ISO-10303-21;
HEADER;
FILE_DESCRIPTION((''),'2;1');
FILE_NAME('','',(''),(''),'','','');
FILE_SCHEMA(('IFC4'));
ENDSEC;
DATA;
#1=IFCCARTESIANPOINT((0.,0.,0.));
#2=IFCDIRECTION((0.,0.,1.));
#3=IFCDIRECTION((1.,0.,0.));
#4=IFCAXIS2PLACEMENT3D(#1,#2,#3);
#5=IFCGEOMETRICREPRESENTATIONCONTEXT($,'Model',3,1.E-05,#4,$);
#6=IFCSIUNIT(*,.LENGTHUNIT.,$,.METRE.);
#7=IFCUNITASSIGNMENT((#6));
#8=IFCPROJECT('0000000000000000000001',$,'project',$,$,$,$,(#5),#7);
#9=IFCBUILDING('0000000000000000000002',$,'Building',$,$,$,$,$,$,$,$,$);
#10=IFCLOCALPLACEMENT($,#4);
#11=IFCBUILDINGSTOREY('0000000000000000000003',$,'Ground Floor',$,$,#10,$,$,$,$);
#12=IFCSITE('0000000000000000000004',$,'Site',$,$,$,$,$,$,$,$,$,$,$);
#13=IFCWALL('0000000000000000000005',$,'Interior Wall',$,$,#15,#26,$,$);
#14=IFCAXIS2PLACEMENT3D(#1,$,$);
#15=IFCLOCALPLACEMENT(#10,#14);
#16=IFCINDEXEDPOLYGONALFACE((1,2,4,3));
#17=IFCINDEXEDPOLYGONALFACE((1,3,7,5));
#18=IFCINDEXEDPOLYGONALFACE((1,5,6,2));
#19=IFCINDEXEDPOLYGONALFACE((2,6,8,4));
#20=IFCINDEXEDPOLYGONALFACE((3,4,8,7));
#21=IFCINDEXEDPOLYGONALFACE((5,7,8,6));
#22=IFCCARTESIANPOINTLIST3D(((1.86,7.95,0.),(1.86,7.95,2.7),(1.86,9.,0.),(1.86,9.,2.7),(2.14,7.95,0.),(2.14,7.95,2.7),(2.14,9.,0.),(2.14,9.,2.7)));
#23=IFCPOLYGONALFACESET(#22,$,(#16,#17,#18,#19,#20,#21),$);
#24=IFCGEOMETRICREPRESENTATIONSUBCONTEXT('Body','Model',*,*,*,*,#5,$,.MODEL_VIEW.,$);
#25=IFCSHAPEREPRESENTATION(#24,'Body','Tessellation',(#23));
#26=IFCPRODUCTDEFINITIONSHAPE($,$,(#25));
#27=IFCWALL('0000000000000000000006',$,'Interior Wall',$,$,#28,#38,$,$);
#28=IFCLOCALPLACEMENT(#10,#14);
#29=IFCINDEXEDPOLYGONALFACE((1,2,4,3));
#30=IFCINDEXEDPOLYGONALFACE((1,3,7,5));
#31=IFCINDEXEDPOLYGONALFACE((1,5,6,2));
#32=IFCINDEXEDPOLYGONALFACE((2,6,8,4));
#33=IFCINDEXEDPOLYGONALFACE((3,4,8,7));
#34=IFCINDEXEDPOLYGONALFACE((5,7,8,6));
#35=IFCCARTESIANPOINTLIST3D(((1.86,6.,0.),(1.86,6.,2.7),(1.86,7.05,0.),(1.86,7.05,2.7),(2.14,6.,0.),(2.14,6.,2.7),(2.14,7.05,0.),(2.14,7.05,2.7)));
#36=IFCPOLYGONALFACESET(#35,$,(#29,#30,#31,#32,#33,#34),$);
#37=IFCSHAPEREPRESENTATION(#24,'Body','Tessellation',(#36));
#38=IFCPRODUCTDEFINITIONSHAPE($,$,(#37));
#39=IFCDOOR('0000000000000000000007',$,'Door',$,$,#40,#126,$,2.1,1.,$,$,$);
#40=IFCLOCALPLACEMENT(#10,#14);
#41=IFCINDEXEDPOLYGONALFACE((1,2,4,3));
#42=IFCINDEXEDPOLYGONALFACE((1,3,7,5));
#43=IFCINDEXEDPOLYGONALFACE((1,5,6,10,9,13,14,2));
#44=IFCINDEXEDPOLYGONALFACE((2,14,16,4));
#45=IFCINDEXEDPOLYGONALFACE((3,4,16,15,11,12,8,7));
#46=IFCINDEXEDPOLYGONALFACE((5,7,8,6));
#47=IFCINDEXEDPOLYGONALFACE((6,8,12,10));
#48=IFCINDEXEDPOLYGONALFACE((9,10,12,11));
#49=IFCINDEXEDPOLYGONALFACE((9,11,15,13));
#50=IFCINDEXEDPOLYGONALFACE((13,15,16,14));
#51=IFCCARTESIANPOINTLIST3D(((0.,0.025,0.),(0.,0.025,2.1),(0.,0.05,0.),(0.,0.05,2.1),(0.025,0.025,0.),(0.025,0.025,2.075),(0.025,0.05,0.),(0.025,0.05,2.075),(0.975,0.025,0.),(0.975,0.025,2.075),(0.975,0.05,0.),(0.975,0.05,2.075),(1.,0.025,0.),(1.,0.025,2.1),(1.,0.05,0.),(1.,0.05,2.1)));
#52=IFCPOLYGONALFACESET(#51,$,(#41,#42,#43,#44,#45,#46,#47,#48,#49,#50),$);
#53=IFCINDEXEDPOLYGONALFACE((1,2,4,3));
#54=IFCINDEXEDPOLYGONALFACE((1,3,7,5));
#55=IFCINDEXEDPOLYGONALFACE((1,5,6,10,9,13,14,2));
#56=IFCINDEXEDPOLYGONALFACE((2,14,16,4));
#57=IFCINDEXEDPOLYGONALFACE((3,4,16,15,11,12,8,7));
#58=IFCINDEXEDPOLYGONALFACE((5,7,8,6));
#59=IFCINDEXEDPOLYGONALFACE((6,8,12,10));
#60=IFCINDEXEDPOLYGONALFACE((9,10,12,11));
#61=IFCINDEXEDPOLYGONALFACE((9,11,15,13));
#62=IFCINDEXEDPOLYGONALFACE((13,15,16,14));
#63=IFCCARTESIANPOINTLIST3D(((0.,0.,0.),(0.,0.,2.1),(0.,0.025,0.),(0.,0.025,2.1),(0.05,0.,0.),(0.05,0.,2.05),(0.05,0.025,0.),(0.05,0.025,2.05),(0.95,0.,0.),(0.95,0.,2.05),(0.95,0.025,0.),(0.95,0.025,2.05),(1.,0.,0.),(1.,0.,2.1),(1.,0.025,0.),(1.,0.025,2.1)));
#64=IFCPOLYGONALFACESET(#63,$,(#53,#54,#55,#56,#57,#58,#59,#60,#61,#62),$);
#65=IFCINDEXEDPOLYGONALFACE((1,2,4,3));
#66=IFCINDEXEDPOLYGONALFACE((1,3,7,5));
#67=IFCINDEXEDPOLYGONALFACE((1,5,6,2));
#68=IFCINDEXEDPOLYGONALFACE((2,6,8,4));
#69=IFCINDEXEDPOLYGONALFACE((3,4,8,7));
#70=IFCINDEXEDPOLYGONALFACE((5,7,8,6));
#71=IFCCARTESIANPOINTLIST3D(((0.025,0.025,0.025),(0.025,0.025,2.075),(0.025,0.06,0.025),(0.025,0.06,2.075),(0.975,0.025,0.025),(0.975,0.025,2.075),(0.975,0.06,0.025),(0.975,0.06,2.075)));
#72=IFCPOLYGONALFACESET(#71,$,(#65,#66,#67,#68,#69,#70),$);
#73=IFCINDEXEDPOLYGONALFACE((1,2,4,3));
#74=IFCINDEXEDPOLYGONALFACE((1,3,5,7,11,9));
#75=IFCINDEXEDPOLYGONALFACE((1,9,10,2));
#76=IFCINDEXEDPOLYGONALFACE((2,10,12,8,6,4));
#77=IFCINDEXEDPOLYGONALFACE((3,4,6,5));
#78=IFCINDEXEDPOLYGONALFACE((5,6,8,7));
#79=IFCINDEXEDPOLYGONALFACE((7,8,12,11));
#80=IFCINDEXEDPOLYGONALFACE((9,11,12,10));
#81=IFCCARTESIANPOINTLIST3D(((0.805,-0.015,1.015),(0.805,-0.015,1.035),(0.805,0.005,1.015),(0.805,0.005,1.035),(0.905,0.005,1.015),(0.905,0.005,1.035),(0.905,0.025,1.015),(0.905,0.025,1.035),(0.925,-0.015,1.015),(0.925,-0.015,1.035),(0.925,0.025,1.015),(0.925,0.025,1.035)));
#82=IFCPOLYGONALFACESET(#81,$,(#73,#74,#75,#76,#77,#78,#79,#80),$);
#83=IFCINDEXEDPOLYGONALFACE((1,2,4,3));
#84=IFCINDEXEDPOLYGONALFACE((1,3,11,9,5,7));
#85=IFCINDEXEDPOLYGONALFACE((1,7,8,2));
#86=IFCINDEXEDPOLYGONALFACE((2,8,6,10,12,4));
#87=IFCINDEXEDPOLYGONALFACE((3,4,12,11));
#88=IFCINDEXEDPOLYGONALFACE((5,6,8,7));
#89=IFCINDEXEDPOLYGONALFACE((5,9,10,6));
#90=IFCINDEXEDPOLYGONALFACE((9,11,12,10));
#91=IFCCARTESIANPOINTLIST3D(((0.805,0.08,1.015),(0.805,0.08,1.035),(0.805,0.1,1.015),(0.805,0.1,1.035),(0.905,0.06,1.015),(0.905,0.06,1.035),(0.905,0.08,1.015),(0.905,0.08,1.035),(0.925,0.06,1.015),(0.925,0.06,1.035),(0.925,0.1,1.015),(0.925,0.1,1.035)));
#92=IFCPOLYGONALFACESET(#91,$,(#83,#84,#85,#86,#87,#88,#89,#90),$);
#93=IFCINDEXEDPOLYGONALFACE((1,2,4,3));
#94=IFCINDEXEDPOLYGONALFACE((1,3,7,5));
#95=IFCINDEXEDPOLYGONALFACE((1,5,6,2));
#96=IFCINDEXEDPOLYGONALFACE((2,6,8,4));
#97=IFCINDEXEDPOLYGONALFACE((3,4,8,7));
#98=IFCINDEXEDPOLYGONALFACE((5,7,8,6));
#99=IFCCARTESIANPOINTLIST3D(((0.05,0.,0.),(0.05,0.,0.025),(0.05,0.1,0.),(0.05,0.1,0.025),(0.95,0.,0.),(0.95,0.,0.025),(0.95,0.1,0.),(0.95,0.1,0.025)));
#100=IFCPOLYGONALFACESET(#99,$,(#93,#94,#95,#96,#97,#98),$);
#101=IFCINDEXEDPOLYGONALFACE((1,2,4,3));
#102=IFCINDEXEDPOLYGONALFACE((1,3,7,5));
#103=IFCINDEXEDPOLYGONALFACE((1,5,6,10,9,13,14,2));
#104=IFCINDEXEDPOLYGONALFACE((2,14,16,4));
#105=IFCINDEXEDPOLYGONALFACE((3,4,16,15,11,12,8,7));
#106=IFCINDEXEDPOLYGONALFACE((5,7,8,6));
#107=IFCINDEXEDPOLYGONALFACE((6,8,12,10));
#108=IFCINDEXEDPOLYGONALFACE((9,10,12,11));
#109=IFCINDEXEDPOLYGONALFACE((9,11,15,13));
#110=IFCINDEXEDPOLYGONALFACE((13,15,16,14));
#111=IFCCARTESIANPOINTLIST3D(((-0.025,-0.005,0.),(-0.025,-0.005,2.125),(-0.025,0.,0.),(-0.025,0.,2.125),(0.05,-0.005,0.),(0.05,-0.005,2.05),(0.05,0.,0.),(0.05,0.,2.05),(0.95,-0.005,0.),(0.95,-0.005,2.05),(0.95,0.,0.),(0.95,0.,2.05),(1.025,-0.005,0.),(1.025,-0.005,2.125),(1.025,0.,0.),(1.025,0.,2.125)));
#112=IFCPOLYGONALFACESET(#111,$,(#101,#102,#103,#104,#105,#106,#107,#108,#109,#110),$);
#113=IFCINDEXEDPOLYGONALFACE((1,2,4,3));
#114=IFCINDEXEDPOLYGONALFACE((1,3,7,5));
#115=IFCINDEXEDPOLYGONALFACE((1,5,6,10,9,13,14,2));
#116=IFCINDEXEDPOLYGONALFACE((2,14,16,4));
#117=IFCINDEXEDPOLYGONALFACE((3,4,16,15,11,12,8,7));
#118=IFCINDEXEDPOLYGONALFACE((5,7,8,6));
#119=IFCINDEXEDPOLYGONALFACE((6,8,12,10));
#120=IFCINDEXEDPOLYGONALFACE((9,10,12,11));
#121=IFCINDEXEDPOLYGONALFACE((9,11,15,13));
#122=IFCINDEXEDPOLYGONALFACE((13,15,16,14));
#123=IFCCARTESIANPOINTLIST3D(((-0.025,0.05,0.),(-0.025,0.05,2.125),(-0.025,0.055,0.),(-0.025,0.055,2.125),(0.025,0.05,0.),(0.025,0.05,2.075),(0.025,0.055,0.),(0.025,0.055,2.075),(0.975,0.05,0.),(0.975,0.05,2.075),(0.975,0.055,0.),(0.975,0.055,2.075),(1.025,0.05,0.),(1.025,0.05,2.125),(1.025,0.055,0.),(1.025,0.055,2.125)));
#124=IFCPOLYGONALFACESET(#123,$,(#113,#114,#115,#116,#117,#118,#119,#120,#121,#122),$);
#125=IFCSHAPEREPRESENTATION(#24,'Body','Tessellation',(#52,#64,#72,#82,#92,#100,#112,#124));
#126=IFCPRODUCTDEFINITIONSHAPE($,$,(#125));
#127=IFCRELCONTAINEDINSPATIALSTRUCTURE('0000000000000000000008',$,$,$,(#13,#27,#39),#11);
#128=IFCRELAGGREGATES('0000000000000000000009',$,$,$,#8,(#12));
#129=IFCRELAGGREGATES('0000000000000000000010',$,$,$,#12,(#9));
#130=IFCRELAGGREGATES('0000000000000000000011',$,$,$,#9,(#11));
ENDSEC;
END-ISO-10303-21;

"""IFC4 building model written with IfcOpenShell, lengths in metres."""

from ifc_helpers import new_model, si_unit, frame, origin_with_axes, place, context, subcontext, project, spatial, line, indexed_curve, outline, extrude, element, save


model = new_model("IFC4")

# Units and contexts
model_context = context("Model", 3, precision=1e-05, world=origin_with_axes())
body_context = subcontext(model_context, "Body", "Model", "MODEL_VIEW")
ifc_project = project(units=[si_unit("LENGTHUNIT", "METRE")], contexts=[model_context])

# Site, building, storey
site = spatial("IfcSite", under=ifc_project, Name="Site")
building = spatial("IfcBuilding", under=site, Name="Building")
storey_placement = place(None, origin_with_axes())
storey = spatial("IfcBuildingStorey", under=building, at=storey_placement, Name="Ground Floor")

# Walls
for number, where, z_axis, x_axis, name in (
    (1, (2.0, 9.0, 0.0), (0.0, 0.0, 1.0), (0.0, -1.0, 0.0), "Interior Wall"),
    (2, (2.0, 7.05, 0.0), (0.0, 0.0, 1.0), (0.0, -1.0, 0.0), "Interior Wall"),
):
    element("IfcWall", number, at=place(storey_placement, frame(where, z_axis=z_axis, x_axis=x_axis)), inside=storey, Name=name, context=body_context, shape_type="SweptSolid", body=[
        extrude(outline(indexed_curve([(0.0, 0.0), (0.0, 0.28), (1.05, 0.28), (1.05, 0.0), (0.0, 0.0)], self_intersect=False)), frame((0.0, -0.14, 0.0), z_axis=(0.0, 0.0, 1.0), x_axis=(1.0, 0.0, 0.0)), (0.0, 0.0, 1.0), 2.7),
    ])

# Door
door_1_placement = place(storey_placement, origin_with_axes())
element("IfcDoor", 3, at=door_1_placement, inside=storey, Name="Door", OverallHeight=2.1, OverallWidth=1.0, context=body_context, shape_type="SweptSolid", body=[
    extrude(outline(indexed_curve([(0.0, 0.0), (0.0, 2.1), (1.0, 2.1), (1.0, 0.0), (0.975, 0.0), (0.975, 2.075), (0.025, 2.075), (0.025, 0.0)], segments=[line(1, 2, 3, 4, 5, 6, 7, 8, 1)])), frame((0.0, 0.025, 0.0), z_axis=(0.0, -1.0, 0.0), x_axis=(1.0, 0.0, 0.0)), (0.0, 0.0, -1.0), 0.025),
    extrude(outline(indexed_curve([(0.0, 0.0), (0.0, 2.1), (1.0, 2.1), (1.0, 0.0), (0.95, 0.0), (0.95, 2.05), (0.05, 2.05), (0.05, 0.0)], segments=[line(1, 2, 3, 4, 5, 6, 7, 8, 1)])), frame((0.0, 0.0, 0.0), z_axis=(0.0, -1.0, 0.0), x_axis=(1.0, 0.0, 0.0)), (0.0, 0.0, -1.0), 0.025),
    extrude(outline(indexed_curve([(0.0, 0.0), (0.95, 0.0), (0.95, 0.035), (0.0, 0.035)], segments=[line(1, 2, 3, 4, 1)])), frame((0.025, 0.025, 0.025), z_axis=(0.0, 0.0, 1.0), x_axis=(1.0, 0.0, 0.0)), (0.0, 0.0, 1.0), 2.05),
    extrude(outline(indexed_curve([(0.0, 0.0), (0.0, -0.04), (-0.12, -0.04), (-0.12, -0.02), (-0.02, -0.02), (-0.02, 0.0)], segments=[line(1, 2, 3, 4, 5, 6, 1)])), frame((0.925, 0.025, 1.015), z_axis=(0.0, 0.0, 1.0), x_axis=(1.0, 0.0, 0.0)), (0.0, 0.0, 1.0), 0.02),
    extrude(outline(indexed_curve([(0.0, 0.0), (0.0, 0.04), (-0.12, 0.04), (-0.12, 0.02), (-0.02, 0.02), (-0.02, 0.0)], segments=[line(1, 2, 3, 4, 5, 6, 1)])), frame((0.925, 0.06, 1.015), z_axis=(0.0, 0.0, 1.0), x_axis=(1.0, 0.0, 0.0)), (0.0, 0.0, 1.0), 0.02),
    extrude(outline(indexed_curve([(0.0, 0.0), (0.9, 0.0), (0.9, 0.1), (0.0, 0.1)], segments=[line(1, 2, 3, 4, 1)])), frame((0.05, 0.0, 0.0), z_axis=(0.0, 0.0, 1.0), x_axis=(1.0, 0.0, 0.0)), (0.0, 0.0, 1.0), 0.025),
    extrude(outline(indexed_curve([(0.0, 0.0), (0.0, 2.125), (1.05, 2.125), (1.05, 0.0), (0.975, 0.0), (0.975, 2.05), (0.075, 2.05), (0.075, 0.0)], segments=[line(1, 2, 3, 4, 5, 6, 7, 8, 1)])), frame((-0.025, -0.005, 0.0), z_axis=(0.0, -1.0, 0.0), x_axis=(1.0, 0.0, 0.0)), (0.0, 0.0, -1.0), 0.005),
    extrude(outline(indexed_curve([(0.0, 0.0), (0.0, 2.125), (1.05, 2.125), (1.05, 0.0), (1.0, 0.0), (1.0, 2.075), (0.05, 2.075), (0.05, 0.0)], segments=[line(1, 2, 3, 4, 5, 6, 7, 8, 1)])), frame((-0.025, 0.05, 0.0), z_axis=(0.0, -1.0, 0.0), x_axis=(1.0, 0.0, 0.0)), (0.0, 0.0, -1.0), 0.005),
])

save(model, "model.ifc")
